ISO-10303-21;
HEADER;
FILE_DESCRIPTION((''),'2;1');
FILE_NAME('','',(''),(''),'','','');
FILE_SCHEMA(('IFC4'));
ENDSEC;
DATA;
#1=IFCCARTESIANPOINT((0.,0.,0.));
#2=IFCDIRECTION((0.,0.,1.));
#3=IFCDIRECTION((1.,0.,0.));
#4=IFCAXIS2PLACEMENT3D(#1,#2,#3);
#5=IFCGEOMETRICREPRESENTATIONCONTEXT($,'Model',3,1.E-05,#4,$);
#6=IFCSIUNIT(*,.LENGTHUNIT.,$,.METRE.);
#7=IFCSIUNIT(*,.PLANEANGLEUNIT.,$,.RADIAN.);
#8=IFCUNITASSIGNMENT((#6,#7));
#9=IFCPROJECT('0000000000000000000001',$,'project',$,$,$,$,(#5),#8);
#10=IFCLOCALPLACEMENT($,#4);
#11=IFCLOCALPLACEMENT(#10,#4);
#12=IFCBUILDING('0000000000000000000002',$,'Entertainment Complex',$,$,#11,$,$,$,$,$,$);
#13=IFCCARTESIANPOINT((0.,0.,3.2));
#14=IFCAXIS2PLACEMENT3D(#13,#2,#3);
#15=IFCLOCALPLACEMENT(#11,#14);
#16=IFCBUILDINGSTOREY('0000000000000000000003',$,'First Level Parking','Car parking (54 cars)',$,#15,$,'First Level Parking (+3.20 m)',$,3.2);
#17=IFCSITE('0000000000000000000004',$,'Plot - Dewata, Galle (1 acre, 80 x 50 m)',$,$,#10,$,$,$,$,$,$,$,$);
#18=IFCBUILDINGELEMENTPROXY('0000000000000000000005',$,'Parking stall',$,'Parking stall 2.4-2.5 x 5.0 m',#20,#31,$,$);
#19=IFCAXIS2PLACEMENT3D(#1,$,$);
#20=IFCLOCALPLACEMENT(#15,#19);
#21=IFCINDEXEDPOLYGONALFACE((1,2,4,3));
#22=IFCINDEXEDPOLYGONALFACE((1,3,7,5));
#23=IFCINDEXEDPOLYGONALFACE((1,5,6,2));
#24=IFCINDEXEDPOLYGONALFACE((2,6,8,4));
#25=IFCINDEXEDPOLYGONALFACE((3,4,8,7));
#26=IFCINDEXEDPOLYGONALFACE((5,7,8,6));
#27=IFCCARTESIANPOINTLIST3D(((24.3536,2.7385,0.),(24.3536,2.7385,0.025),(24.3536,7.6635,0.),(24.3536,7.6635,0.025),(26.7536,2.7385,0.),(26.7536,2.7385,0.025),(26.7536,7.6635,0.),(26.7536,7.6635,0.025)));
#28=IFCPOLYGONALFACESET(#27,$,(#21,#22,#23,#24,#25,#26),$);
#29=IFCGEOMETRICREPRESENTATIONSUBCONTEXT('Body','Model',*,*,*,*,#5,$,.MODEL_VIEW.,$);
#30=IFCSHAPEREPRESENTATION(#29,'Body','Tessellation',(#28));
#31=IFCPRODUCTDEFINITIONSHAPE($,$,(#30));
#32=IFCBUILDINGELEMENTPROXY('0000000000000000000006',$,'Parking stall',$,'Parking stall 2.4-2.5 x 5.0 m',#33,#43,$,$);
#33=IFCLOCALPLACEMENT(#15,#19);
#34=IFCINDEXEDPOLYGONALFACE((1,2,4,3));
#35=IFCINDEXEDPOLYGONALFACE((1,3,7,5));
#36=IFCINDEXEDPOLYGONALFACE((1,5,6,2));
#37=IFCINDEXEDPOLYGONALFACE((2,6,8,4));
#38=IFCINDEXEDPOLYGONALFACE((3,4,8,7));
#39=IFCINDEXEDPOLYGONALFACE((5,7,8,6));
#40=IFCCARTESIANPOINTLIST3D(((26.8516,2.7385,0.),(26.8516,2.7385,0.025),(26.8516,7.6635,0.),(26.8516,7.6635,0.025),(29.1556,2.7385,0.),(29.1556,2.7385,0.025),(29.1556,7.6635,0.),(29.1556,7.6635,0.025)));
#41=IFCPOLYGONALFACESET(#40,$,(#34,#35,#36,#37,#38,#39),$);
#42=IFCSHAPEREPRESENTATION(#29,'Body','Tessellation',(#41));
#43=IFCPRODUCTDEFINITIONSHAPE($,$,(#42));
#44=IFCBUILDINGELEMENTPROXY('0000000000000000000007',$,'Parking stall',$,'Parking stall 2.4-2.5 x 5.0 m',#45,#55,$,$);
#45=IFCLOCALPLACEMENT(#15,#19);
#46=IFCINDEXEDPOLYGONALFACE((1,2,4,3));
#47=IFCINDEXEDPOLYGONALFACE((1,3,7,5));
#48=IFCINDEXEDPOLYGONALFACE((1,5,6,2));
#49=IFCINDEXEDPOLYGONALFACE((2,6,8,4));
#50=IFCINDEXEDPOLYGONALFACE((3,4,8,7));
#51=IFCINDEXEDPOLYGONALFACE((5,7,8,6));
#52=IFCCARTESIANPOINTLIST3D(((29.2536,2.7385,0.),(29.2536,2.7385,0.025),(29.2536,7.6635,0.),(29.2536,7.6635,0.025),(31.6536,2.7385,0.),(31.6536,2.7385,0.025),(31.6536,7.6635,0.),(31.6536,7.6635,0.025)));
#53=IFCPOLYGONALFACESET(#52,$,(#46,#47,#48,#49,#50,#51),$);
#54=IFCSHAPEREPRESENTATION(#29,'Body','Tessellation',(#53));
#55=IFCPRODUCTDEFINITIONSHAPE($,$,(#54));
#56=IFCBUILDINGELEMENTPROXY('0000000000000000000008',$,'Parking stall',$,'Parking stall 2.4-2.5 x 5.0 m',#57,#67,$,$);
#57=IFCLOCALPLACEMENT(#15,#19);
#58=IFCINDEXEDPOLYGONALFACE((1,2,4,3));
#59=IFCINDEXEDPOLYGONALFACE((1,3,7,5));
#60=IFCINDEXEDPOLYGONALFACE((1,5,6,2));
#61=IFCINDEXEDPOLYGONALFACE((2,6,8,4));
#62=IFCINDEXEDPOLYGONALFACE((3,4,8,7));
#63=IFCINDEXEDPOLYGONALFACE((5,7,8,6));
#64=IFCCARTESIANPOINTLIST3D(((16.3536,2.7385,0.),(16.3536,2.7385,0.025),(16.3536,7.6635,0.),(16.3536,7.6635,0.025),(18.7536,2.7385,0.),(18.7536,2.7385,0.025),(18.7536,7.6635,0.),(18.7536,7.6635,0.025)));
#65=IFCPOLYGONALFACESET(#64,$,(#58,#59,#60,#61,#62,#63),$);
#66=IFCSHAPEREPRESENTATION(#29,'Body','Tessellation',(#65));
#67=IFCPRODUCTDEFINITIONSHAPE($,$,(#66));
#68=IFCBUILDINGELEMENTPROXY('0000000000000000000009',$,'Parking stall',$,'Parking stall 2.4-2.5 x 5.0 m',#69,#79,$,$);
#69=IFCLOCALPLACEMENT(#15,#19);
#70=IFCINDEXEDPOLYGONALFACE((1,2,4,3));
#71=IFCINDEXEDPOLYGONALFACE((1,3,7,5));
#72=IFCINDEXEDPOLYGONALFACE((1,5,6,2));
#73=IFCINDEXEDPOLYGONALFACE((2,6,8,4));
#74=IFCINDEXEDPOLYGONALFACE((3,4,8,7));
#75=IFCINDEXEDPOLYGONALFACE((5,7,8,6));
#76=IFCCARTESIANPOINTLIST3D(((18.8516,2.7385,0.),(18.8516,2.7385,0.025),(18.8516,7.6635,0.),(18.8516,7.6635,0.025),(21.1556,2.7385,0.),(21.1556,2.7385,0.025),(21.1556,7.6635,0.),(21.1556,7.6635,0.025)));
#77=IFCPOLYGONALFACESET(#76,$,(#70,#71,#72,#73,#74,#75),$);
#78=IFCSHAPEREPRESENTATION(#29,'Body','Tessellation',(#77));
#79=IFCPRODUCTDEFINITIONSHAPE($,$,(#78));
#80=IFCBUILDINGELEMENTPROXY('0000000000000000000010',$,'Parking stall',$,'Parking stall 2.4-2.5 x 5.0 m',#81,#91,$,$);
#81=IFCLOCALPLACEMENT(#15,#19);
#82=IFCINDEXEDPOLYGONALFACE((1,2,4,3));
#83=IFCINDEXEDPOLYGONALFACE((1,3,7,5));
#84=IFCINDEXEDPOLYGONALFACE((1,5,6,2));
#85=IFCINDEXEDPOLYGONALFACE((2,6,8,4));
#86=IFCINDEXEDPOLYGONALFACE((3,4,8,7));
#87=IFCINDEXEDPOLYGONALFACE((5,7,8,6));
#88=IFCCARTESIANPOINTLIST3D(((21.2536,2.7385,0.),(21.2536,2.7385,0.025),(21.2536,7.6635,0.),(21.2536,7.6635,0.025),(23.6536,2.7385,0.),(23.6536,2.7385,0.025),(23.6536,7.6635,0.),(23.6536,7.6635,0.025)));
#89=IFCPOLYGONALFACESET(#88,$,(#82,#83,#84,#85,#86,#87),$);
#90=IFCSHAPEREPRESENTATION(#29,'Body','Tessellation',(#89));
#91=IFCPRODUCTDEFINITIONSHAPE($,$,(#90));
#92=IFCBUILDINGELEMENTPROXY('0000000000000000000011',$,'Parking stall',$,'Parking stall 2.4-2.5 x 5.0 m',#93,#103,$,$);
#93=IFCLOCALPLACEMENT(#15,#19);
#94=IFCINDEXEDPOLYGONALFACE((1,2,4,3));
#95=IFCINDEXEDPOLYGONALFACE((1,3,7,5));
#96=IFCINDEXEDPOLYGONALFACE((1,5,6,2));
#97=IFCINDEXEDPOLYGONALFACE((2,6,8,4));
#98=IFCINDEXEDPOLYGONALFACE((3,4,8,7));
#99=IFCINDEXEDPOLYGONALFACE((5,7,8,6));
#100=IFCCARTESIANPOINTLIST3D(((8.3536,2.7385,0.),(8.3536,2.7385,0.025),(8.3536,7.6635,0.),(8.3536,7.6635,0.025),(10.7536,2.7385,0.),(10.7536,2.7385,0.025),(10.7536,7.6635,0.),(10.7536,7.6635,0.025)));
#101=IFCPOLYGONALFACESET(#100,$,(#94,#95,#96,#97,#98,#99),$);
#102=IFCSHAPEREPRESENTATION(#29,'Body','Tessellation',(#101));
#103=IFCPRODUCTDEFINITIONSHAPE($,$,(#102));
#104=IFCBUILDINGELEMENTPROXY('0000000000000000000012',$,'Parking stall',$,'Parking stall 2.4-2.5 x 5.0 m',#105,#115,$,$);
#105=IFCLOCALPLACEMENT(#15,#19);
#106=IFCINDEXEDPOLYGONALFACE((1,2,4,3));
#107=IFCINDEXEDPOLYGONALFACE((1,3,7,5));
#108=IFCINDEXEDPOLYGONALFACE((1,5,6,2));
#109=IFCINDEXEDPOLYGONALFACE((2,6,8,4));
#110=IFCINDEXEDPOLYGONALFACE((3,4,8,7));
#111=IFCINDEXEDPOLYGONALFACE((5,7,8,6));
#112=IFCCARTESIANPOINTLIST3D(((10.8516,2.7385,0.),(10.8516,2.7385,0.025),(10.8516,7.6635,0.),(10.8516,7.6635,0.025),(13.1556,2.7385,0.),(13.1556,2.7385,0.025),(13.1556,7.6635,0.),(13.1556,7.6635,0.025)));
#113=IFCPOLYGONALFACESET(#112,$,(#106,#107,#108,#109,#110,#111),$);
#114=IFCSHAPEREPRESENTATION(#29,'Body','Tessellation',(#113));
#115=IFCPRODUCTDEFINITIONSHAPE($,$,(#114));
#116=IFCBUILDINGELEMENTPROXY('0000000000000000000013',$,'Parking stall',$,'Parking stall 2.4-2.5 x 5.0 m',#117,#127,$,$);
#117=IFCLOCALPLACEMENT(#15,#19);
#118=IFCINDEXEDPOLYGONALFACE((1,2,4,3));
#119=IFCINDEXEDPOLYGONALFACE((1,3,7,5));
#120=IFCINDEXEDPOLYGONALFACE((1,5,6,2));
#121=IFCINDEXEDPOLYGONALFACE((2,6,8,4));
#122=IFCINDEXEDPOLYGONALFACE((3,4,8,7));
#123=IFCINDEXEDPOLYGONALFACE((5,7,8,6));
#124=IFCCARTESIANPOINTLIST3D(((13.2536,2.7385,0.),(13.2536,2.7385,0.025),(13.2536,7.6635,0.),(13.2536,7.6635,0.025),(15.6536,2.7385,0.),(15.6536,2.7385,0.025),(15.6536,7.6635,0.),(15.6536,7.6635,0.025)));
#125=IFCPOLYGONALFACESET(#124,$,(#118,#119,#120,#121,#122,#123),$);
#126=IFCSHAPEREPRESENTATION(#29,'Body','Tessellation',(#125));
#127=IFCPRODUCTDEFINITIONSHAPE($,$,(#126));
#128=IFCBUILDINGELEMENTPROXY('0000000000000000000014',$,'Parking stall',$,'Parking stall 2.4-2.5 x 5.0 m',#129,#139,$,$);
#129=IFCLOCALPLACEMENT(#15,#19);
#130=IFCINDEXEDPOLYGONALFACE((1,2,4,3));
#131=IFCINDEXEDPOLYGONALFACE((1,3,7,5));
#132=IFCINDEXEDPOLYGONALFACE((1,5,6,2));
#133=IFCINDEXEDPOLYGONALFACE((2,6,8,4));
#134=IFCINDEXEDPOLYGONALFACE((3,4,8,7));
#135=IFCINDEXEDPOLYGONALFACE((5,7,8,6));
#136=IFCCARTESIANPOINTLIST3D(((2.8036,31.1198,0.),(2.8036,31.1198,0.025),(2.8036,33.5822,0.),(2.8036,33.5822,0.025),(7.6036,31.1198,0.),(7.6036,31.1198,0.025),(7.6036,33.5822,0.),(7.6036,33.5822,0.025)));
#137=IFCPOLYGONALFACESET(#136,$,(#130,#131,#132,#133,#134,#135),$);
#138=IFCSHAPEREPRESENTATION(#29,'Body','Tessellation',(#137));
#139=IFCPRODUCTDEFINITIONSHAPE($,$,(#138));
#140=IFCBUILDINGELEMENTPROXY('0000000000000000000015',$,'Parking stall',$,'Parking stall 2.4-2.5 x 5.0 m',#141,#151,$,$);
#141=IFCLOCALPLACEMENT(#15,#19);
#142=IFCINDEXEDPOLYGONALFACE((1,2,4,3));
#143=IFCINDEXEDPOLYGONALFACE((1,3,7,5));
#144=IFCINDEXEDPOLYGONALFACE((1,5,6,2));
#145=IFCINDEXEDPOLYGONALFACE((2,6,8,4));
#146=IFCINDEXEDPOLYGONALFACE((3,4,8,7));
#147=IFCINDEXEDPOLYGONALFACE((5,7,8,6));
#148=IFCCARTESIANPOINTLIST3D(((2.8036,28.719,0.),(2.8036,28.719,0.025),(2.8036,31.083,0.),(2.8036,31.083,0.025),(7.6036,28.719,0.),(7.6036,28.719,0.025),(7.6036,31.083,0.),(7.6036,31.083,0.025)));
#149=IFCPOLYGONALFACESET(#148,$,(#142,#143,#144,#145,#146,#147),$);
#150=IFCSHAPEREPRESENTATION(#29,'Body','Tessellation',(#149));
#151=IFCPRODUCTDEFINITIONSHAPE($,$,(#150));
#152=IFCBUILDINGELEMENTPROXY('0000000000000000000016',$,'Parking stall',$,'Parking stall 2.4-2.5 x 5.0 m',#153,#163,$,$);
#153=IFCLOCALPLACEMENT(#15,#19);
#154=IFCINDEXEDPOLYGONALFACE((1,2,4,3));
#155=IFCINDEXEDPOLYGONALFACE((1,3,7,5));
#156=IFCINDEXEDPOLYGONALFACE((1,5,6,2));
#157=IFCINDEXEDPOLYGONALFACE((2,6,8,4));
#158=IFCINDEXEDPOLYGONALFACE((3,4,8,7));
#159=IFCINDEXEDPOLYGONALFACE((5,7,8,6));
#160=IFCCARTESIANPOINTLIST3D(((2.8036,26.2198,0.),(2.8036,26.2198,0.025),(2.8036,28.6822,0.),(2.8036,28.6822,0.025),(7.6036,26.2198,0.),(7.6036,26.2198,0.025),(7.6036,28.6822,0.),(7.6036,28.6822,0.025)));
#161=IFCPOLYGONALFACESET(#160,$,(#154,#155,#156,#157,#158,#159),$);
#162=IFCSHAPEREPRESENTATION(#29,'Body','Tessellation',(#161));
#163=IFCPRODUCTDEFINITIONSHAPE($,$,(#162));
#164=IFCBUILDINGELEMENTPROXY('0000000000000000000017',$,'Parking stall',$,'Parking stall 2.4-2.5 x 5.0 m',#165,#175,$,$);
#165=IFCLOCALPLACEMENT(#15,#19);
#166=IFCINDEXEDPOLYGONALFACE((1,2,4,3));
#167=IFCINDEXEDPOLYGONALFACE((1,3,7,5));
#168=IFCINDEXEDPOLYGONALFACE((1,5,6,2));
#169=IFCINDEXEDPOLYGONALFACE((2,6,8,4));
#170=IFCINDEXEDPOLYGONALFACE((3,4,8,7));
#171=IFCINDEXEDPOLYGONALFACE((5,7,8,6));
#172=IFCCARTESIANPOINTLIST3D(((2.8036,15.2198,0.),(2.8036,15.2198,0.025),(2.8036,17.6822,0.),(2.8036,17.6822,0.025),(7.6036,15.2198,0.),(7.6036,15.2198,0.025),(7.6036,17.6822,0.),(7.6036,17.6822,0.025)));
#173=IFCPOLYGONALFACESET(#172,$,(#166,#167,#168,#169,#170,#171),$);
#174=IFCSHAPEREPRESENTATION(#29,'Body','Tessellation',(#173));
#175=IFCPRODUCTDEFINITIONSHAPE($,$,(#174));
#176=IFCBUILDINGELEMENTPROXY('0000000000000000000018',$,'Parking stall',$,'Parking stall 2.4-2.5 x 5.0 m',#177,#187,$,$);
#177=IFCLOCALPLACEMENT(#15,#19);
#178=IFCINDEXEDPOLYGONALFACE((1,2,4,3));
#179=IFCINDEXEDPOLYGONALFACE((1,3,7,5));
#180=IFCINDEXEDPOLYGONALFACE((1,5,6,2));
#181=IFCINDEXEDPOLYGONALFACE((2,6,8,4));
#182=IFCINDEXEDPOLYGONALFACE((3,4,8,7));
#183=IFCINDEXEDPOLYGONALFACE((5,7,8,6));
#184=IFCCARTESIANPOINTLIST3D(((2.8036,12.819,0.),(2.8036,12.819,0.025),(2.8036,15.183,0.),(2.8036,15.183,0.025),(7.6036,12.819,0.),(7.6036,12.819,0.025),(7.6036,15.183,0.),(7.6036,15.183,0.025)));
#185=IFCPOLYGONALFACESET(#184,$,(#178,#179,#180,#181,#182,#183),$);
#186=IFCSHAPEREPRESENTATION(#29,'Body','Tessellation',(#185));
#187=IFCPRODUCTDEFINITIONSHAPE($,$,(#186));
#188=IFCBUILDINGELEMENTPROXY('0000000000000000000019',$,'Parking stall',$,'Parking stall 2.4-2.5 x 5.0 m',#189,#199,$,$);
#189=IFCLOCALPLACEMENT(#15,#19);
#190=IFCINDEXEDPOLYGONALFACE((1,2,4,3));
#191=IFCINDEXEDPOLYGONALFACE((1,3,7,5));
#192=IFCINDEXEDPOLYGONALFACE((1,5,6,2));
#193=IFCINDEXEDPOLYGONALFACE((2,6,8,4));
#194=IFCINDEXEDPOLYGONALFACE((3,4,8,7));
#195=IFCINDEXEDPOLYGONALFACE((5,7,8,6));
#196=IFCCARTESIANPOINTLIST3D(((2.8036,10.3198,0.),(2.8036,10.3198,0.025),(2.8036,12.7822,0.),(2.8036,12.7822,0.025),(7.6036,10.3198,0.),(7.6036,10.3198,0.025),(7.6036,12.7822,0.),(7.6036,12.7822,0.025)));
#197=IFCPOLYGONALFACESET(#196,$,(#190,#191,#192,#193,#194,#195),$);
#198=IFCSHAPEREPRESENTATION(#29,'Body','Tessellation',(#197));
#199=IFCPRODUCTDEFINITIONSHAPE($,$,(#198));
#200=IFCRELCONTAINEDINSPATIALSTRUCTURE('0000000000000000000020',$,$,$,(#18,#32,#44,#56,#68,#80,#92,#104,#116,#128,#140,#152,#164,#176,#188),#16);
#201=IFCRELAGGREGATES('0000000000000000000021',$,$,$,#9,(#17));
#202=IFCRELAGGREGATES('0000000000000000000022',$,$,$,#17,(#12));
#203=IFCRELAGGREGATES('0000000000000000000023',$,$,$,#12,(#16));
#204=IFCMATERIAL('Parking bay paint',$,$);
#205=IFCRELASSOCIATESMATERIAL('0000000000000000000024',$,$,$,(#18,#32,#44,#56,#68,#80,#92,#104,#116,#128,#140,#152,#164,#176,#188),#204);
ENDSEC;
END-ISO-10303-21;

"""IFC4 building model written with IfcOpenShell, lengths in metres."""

from ifc_helpers import new_model, si_unit, frame, origin_with_axes, place, context, subcontext, project, spatial, polyline, outline, extrude, material, element, save


model = new_model("IFC4")

# Units and contexts
model_context = context("Model", 3, precision=1e-05, world=origin_with_axes())
body_context = subcontext(model_context, "Body", "Model", "MODEL_VIEW")
ifc_project = project(units=[si_unit("LENGTHUNIT", "METRE"), si_unit("PLANEANGLEUNIT", "RADIAN")], contexts=[model_context])

# Site, building, storey
site_placement = place(None, origin_with_axes())
site = spatial("IfcSite", under=ifc_project, at=site_placement, Name="Plot - Dewata, Galle (1 acre, 80 x 50 m)")
building_placement = place(site_placement, origin_with_axes())
building = spatial("IfcBuilding", under=site, at=building_placement, Name="Entertainment Complex")
storey_placement = place(building_placement, frame((0.0, 0.0, 3.2), z_axis=(0.0, 0.0, 1.0), x_axis=(1.0, 0.0, 0.0)))
storey = spatial("IfcBuildingStorey", under=building, at=storey_placement, Name="First Level Parking", Description="Car parking (54 cars)", LongName="First Level Parking (+3.20 m)", Elevation=3.2)

# Building element proxies
ifc_material_1 = material(Name="Parking bay paint")
proxy_1_placement = place(storey_placement, origin_with_axes())
element("IfcBuildingElementProxy", 1, at=proxy_1_placement, inside=storey, material=ifc_material_1, Name="Parking stall", ObjectType="Parking stall 2.4-2.5 x 5.0 m", context=body_context, shape_type="SweptSolid", body=[
    extrude(outline(polyline([(24.3536, 2.7385), (26.7536, 2.7385), (26.7536, 7.6635), (24.3536, 7.6635), (24.3536, 2.7385)])), origin_with_axes(), (0.0, 0.0, 1.0), 0.025),
])
proxy_2_placement = place(storey_placement, origin_with_axes())
element("IfcBuildingElementProxy", 2, at=proxy_2_placement, inside=storey, material=ifc_material_1, Name="Parking stall", ObjectType="Parking stall 2.4-2.5 x 5.0 m", context=body_context, shape_type="SweptSolid", body=[
    extrude(outline(polyline([(26.8516, 2.7385), (29.1556, 2.7385), (29.1556, 7.6635), (26.8516, 7.6635), (26.8516, 2.7385)])), origin_with_axes(), (0.0, 0.0, 1.0), 0.025),
])
proxy_3_placement = place(storey_placement, origin_with_axes())
element("IfcBuildingElementProxy", 3, at=proxy_3_placement, inside=storey, material=ifc_material_1, Name="Parking stall", ObjectType="Parking stall 2.4-2.5 x 5.0 m", context=body_context, shape_type="SweptSolid", body=[
    extrude(outline(polyline([(29.2536, 2.7385), (31.6536, 2.7385), (31.6536, 7.6635), (29.2536, 7.6635), (29.2536, 2.7385)])), origin_with_axes(), (0.0, 0.0, 1.0), 0.025),
])
proxy_4_placement = place(storey_placement, origin_with_axes())
element("IfcBuildingElementProxy", 4, at=proxy_4_placement, inside=storey, material=ifc_material_1, Name="Parking stall", ObjectType="Parking stall 2.4-2.5 x 5.0 m", context=body_context, shape_type="SweptSolid", body=[
    extrude(outline(polyline([(16.3536, 2.7385), (18.7536, 2.7385), (18.7536, 7.6635), (16.3536, 7.6635), (16.3536, 2.7385)])), origin_with_axes(), (0.0, 0.0, 1.0), 0.025),
])
proxy_5_placement = place(storey_placement, origin_with_axes())
element("IfcBuildingElementProxy", 5, at=proxy_5_placement, inside=storey, material=ifc_material_1, Name="Parking stall", ObjectType="Parking stall 2.4-2.5 x 5.0 m", context=body_context, shape_type="SweptSolid", body=[
    extrude(outline(polyline([(18.8516, 2.7385), (21.1556, 2.7385), (21.1556, 7.6635), (18.8516, 7.6635), (18.8516, 2.7385)])), origin_with_axes(), (0.0, 0.0, 1.0), 0.025),
])
proxy_6_placement = place(storey_placement, origin_with_axes())
element("IfcBuildingElementProxy", 6, at=proxy_6_placement, inside=storey, material=ifc_material_1, Name="Parking stall", ObjectType="Parking stall 2.4-2.5 x 5.0 m", context=body_context, shape_type="SweptSolid", body=[
    extrude(outline(polyline([(21.2536, 2.7385), (23.6536, 2.7385), (23.6536, 7.6635), (21.2536, 7.6635), (21.2536, 2.7385)])), origin_with_axes(), (0.0, 0.0, 1.0), 0.025),
])
proxy_7_placement = place(storey_placement, origin_with_axes())
element("IfcBuildingElementProxy", 7, at=proxy_7_placement, inside=storey, material=ifc_material_1, Name="Parking stall", ObjectType="Parking stall 2.4-2.5 x 5.0 m", context=body_context, shape_type="SweptSolid", body=[
    extrude(outline(polyline([(8.3536, 2.7385), (10.7536, 2.7385), (10.7536, 7.6635), (8.3536, 7.6635), (8.3536, 2.7385)])), origin_with_axes(), (0.0, 0.0, 1.0), 0.025),
])
proxy_8_placement = place(storey_placement, origin_with_axes())
element("IfcBuildingElementProxy", 8, at=proxy_8_placement, inside=storey, material=ifc_material_1, Name="Parking stall", ObjectType="Parking stall 2.4-2.5 x 5.0 m", context=body_context, shape_type="SweptSolid", body=[
    extrude(outline(polyline([(10.8516, 2.7385), (13.1556, 2.7385), (13.1556, 7.6635), (10.8516, 7.6635), (10.8516, 2.7385)])), origin_with_axes(), (0.0, 0.0, 1.0), 0.025),
])
proxy_9_placement = place(storey_placement, origin_with_axes())
element("IfcBuildingElementProxy", 9, at=proxy_9_placement, inside=storey, material=ifc_material_1, Name="Parking stall", ObjectType="Parking stall 2.4-2.5 x 5.0 m", context=body_context, shape_type="SweptSolid", body=[
    extrude(outline(polyline([(13.2536, 2.7385), (15.6536, 2.7385), (15.6536, 7.6635), (13.2536, 7.6635), (13.2536, 2.7385)])), origin_with_axes(), (0.0, 0.0, 1.0), 0.025),
])
proxy_10_placement = place(storey_placement, origin_with_axes())
element("IfcBuildingElementProxy", 10, at=proxy_10_placement, inside=storey, material=ifc_material_1, Name="Parking stall", ObjectType="Parking stall 2.4-2.5 x 5.0 m", context=body_context, shape_type="SweptSolid", body=[
    extrude(outline(polyline([(2.8036, 33.5823), (2.8036, 31.1197), (7.6036, 31.1197), (7.6036, 33.5823), (2.8036, 33.5823)])), origin_with_axes(), (0.0, 0.0, 1.0), 0.025),
])
proxy_11_placement = place(storey_placement, origin_with_axes())
element("IfcBuildingElementProxy", 11, at=proxy_11_placement, inside=storey, material=ifc_material_1, Name="Parking stall", ObjectType="Parking stall 2.4-2.5 x 5.0 m", context=body_context, shape_type="SweptSolid", body=[
    extrude(outline(polyline([(2.8036, 31.083), (2.8036, 28.719), (7.6036, 28.719), (7.6036, 31.083), (2.8036, 31.083)])), origin_with_axes(), (0.0, 0.0, 1.0), 0.025),
])
proxy_12_placement = place(storey_placement, origin_with_axes())
element("IfcBuildingElementProxy", 12, at=proxy_12_placement, inside=storey, material=ifc_material_1, Name="Parking stall", ObjectType="Parking stall 2.4-2.5 x 5.0 m", context=body_context, shape_type="SweptSolid", body=[
    extrude(outline(polyline([(2.8036, 28.6822), (2.8036, 26.2198), (7.6036, 26.2198), (7.6036, 28.6822), (2.8036, 28.6822)])), origin_with_axes(), (0.0, 0.0, 1.0), 0.025),
])
proxy_13_placement = place(storey_placement, origin_with_axes())
element("IfcBuildingElementProxy", 13, at=proxy_13_placement, inside=storey, material=ifc_material_1, Name="Parking stall", ObjectType="Parking stall 2.4-2.5 x 5.0 m", context=body_context, shape_type="SweptSolid", body=[
    extrude(outline(polyline([(2.8036, 17.6822), (2.8036, 15.2198), (7.6036, 15.2198), (7.6036, 17.6822), (2.8036, 17.6822)])), origin_with_axes(), (0.0, 0.0, 1.0), 0.025),
])
proxy_14_placement = place(storey_placement, origin_with_axes())
element("IfcBuildingElementProxy", 14, at=proxy_14_placement, inside=storey, material=ifc_material_1, Name="Parking stall", ObjectType="Parking stall 2.4-2.5 x 5.0 m", context=body_context, shape_type="SweptSolid", body=[
    extrude(outline(polyline([(2.8036, 15.183), (2.8036, 12.819), (7.6036, 12.819), (7.6036, 15.183), (2.8036, 15.183)])), origin_with_axes(), (0.0, 0.0, 1.0), 0.025),
])
proxy_15_placement = place(storey_placement, origin_with_axes())
element("IfcBuildingElementProxy", 15, at=proxy_15_placement, inside=storey, material=ifc_material_1, Name="Parking stall", ObjectType="Parking stall 2.4-2.5 x 5.0 m", context=body_context, shape_type="SweptSolid", body=[
    extrude(outline(polyline([(2.8036, 12.7822), (2.8036, 10.3198), (7.6036, 10.3198), (7.6036, 12.7822), (2.8036, 12.7822)])), origin_with_axes(), (0.0, 0.0, 1.0), 0.025),
])

save(model, "model.ifc")
